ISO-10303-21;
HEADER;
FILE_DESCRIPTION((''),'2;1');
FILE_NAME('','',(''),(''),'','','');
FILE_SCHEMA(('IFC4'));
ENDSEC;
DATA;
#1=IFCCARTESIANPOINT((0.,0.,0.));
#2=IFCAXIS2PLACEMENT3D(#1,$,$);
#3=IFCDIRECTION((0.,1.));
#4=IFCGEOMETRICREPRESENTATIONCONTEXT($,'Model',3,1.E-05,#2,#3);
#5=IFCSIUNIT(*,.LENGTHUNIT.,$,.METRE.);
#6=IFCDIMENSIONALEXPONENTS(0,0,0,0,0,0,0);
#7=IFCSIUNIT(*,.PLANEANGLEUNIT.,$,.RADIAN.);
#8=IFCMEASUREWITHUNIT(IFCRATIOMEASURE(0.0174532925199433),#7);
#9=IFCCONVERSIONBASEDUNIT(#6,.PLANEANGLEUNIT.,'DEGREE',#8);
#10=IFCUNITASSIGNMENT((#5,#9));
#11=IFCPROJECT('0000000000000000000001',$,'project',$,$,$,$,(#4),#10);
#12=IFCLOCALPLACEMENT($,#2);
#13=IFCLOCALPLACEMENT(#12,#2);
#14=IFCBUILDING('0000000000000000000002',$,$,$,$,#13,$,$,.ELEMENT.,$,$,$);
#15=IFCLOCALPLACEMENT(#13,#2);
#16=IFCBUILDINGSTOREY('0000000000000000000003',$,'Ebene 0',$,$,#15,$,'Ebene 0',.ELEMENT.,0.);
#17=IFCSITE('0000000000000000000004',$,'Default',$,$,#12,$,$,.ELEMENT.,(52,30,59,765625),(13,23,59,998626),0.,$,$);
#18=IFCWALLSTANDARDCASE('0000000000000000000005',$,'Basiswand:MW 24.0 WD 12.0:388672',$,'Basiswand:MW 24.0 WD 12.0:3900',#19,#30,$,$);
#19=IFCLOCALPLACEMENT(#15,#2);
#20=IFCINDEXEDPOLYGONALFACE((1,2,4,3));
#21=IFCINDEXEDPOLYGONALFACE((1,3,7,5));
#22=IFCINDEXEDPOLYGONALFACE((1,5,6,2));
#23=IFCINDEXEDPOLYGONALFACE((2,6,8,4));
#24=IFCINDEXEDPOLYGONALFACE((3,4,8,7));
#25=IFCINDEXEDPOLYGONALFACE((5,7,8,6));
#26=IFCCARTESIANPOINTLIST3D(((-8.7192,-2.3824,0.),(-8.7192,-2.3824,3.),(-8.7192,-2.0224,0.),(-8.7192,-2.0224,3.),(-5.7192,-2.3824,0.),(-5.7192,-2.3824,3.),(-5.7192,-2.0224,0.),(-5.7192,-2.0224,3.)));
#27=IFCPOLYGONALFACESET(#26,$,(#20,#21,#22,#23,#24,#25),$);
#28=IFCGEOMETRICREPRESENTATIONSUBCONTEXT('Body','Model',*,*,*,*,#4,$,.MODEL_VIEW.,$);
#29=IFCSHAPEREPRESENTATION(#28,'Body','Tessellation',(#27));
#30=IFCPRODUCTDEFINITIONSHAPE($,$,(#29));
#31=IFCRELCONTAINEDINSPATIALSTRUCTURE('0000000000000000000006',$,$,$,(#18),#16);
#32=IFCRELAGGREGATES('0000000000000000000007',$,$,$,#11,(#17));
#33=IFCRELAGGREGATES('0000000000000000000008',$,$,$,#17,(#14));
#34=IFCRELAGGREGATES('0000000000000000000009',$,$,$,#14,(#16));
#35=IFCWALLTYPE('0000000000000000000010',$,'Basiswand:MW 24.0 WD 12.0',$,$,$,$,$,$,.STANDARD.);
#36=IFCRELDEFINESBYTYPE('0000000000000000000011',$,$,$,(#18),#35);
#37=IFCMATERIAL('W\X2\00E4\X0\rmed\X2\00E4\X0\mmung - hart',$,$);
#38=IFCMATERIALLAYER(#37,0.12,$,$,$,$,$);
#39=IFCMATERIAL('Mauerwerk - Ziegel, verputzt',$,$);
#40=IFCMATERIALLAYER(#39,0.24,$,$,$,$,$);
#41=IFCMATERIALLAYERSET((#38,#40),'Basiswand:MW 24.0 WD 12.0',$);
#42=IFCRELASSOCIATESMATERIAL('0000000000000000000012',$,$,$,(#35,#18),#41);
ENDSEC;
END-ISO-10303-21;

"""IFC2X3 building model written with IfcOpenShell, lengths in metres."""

from ifc_helpers import new_model, entity, si_unit, converted_unit, direction, frame, frame_2d, origin, place, context, subcontext, project, spatial, rectangle, extrude, material, layer, layer_set, layer_usage, type_object, element, save


model = new_model("IFC2X3")

# Units and contexts
model_context = context("Model", 3, precision=1e-05, world=origin(), true_north=direction((0.0, 1.0)))
body_context = subcontext(model_context, "Body", "Model", "MODEL_VIEW")
ifc_project = project(units=[si_unit("LENGTHUNIT", "METRE"), converted_unit("PLANEANGLEUNIT", "DEGREE", entity("IfcRatioMeasure", 0.0174532925199433), si_unit("PLANEANGLEUNIT", "RADIAN"), dimensions=[0, 0, 0, 0, 0, 0, 0])], contexts=[model_context])

# Site, building, storey
site_placement = place(None, origin())
site = spatial("IfcSite", under=ifc_project, at=site_placement, Name="Default", CompositionType="ELEMENT", RefLatitude=(52, 30, 59, 765625), RefLongitude=(13, 23, 59, 998626), RefElevation=0.0)
building_placement = place(site_placement, origin())
building = spatial("IfcBuilding", under=site, at=building_placement, CompositionType="ELEMENT")
storey_placement = place(building_placement, origin())
storey = spatial("IfcBuildingStorey", under=building, at=storey_placement, Name="Ebene 0", LongName="Ebene 0", CompositionType="ELEMENT", Elevation=0.0)

# Wall
ifc_material_1 = material(Name="Wärmedämmung - hart")
ifc_layer_1 = layer(ifc_material_1, 0.12)
ifc_material_2 = material(Name="Mauerwerk - Ziegel, verputzt")
ifc_layer_2 = layer(ifc_material_2, 0.24)
ifc_layer_set = layer_set([ifc_layer_1, ifc_layer_2], Name="Basiswand:MW 24.0 WD 12.0")
ifc_layer_usage = layer_usage(ifc_layer_set, "AXIS2", "NEGATIVE", 0.18)
wall_type = type_object("IfcWallType", Name="Basiswand:MW 24.0 WD 12.0", PredefinedType="STANDARD", material=ifc_layer_set)
wall_placement = place(storey_placement, frame((-8.7192, -2.2024, 0.0)))
element("IfcWallStandardCase", 1, at=wall_placement, inside=storey, type_object=wall_type, material=ifc_layer_usage, Name="Basiswand:MW 24.0 WD 12.0:388672", ObjectType="Basiswand:MW 24.0 WD 12.0:3900", context=body_context, shape_type="SweptSolid", body=[
    extrude(rectangle(XDim=3.0, YDim=0.36, at=frame_2d((1.5, 0.0), x_axis=(-1.0, 0.0))), origin(), (0.0, 0.0, 1.0), 3.0),
])

save(model, "model.ifc")
